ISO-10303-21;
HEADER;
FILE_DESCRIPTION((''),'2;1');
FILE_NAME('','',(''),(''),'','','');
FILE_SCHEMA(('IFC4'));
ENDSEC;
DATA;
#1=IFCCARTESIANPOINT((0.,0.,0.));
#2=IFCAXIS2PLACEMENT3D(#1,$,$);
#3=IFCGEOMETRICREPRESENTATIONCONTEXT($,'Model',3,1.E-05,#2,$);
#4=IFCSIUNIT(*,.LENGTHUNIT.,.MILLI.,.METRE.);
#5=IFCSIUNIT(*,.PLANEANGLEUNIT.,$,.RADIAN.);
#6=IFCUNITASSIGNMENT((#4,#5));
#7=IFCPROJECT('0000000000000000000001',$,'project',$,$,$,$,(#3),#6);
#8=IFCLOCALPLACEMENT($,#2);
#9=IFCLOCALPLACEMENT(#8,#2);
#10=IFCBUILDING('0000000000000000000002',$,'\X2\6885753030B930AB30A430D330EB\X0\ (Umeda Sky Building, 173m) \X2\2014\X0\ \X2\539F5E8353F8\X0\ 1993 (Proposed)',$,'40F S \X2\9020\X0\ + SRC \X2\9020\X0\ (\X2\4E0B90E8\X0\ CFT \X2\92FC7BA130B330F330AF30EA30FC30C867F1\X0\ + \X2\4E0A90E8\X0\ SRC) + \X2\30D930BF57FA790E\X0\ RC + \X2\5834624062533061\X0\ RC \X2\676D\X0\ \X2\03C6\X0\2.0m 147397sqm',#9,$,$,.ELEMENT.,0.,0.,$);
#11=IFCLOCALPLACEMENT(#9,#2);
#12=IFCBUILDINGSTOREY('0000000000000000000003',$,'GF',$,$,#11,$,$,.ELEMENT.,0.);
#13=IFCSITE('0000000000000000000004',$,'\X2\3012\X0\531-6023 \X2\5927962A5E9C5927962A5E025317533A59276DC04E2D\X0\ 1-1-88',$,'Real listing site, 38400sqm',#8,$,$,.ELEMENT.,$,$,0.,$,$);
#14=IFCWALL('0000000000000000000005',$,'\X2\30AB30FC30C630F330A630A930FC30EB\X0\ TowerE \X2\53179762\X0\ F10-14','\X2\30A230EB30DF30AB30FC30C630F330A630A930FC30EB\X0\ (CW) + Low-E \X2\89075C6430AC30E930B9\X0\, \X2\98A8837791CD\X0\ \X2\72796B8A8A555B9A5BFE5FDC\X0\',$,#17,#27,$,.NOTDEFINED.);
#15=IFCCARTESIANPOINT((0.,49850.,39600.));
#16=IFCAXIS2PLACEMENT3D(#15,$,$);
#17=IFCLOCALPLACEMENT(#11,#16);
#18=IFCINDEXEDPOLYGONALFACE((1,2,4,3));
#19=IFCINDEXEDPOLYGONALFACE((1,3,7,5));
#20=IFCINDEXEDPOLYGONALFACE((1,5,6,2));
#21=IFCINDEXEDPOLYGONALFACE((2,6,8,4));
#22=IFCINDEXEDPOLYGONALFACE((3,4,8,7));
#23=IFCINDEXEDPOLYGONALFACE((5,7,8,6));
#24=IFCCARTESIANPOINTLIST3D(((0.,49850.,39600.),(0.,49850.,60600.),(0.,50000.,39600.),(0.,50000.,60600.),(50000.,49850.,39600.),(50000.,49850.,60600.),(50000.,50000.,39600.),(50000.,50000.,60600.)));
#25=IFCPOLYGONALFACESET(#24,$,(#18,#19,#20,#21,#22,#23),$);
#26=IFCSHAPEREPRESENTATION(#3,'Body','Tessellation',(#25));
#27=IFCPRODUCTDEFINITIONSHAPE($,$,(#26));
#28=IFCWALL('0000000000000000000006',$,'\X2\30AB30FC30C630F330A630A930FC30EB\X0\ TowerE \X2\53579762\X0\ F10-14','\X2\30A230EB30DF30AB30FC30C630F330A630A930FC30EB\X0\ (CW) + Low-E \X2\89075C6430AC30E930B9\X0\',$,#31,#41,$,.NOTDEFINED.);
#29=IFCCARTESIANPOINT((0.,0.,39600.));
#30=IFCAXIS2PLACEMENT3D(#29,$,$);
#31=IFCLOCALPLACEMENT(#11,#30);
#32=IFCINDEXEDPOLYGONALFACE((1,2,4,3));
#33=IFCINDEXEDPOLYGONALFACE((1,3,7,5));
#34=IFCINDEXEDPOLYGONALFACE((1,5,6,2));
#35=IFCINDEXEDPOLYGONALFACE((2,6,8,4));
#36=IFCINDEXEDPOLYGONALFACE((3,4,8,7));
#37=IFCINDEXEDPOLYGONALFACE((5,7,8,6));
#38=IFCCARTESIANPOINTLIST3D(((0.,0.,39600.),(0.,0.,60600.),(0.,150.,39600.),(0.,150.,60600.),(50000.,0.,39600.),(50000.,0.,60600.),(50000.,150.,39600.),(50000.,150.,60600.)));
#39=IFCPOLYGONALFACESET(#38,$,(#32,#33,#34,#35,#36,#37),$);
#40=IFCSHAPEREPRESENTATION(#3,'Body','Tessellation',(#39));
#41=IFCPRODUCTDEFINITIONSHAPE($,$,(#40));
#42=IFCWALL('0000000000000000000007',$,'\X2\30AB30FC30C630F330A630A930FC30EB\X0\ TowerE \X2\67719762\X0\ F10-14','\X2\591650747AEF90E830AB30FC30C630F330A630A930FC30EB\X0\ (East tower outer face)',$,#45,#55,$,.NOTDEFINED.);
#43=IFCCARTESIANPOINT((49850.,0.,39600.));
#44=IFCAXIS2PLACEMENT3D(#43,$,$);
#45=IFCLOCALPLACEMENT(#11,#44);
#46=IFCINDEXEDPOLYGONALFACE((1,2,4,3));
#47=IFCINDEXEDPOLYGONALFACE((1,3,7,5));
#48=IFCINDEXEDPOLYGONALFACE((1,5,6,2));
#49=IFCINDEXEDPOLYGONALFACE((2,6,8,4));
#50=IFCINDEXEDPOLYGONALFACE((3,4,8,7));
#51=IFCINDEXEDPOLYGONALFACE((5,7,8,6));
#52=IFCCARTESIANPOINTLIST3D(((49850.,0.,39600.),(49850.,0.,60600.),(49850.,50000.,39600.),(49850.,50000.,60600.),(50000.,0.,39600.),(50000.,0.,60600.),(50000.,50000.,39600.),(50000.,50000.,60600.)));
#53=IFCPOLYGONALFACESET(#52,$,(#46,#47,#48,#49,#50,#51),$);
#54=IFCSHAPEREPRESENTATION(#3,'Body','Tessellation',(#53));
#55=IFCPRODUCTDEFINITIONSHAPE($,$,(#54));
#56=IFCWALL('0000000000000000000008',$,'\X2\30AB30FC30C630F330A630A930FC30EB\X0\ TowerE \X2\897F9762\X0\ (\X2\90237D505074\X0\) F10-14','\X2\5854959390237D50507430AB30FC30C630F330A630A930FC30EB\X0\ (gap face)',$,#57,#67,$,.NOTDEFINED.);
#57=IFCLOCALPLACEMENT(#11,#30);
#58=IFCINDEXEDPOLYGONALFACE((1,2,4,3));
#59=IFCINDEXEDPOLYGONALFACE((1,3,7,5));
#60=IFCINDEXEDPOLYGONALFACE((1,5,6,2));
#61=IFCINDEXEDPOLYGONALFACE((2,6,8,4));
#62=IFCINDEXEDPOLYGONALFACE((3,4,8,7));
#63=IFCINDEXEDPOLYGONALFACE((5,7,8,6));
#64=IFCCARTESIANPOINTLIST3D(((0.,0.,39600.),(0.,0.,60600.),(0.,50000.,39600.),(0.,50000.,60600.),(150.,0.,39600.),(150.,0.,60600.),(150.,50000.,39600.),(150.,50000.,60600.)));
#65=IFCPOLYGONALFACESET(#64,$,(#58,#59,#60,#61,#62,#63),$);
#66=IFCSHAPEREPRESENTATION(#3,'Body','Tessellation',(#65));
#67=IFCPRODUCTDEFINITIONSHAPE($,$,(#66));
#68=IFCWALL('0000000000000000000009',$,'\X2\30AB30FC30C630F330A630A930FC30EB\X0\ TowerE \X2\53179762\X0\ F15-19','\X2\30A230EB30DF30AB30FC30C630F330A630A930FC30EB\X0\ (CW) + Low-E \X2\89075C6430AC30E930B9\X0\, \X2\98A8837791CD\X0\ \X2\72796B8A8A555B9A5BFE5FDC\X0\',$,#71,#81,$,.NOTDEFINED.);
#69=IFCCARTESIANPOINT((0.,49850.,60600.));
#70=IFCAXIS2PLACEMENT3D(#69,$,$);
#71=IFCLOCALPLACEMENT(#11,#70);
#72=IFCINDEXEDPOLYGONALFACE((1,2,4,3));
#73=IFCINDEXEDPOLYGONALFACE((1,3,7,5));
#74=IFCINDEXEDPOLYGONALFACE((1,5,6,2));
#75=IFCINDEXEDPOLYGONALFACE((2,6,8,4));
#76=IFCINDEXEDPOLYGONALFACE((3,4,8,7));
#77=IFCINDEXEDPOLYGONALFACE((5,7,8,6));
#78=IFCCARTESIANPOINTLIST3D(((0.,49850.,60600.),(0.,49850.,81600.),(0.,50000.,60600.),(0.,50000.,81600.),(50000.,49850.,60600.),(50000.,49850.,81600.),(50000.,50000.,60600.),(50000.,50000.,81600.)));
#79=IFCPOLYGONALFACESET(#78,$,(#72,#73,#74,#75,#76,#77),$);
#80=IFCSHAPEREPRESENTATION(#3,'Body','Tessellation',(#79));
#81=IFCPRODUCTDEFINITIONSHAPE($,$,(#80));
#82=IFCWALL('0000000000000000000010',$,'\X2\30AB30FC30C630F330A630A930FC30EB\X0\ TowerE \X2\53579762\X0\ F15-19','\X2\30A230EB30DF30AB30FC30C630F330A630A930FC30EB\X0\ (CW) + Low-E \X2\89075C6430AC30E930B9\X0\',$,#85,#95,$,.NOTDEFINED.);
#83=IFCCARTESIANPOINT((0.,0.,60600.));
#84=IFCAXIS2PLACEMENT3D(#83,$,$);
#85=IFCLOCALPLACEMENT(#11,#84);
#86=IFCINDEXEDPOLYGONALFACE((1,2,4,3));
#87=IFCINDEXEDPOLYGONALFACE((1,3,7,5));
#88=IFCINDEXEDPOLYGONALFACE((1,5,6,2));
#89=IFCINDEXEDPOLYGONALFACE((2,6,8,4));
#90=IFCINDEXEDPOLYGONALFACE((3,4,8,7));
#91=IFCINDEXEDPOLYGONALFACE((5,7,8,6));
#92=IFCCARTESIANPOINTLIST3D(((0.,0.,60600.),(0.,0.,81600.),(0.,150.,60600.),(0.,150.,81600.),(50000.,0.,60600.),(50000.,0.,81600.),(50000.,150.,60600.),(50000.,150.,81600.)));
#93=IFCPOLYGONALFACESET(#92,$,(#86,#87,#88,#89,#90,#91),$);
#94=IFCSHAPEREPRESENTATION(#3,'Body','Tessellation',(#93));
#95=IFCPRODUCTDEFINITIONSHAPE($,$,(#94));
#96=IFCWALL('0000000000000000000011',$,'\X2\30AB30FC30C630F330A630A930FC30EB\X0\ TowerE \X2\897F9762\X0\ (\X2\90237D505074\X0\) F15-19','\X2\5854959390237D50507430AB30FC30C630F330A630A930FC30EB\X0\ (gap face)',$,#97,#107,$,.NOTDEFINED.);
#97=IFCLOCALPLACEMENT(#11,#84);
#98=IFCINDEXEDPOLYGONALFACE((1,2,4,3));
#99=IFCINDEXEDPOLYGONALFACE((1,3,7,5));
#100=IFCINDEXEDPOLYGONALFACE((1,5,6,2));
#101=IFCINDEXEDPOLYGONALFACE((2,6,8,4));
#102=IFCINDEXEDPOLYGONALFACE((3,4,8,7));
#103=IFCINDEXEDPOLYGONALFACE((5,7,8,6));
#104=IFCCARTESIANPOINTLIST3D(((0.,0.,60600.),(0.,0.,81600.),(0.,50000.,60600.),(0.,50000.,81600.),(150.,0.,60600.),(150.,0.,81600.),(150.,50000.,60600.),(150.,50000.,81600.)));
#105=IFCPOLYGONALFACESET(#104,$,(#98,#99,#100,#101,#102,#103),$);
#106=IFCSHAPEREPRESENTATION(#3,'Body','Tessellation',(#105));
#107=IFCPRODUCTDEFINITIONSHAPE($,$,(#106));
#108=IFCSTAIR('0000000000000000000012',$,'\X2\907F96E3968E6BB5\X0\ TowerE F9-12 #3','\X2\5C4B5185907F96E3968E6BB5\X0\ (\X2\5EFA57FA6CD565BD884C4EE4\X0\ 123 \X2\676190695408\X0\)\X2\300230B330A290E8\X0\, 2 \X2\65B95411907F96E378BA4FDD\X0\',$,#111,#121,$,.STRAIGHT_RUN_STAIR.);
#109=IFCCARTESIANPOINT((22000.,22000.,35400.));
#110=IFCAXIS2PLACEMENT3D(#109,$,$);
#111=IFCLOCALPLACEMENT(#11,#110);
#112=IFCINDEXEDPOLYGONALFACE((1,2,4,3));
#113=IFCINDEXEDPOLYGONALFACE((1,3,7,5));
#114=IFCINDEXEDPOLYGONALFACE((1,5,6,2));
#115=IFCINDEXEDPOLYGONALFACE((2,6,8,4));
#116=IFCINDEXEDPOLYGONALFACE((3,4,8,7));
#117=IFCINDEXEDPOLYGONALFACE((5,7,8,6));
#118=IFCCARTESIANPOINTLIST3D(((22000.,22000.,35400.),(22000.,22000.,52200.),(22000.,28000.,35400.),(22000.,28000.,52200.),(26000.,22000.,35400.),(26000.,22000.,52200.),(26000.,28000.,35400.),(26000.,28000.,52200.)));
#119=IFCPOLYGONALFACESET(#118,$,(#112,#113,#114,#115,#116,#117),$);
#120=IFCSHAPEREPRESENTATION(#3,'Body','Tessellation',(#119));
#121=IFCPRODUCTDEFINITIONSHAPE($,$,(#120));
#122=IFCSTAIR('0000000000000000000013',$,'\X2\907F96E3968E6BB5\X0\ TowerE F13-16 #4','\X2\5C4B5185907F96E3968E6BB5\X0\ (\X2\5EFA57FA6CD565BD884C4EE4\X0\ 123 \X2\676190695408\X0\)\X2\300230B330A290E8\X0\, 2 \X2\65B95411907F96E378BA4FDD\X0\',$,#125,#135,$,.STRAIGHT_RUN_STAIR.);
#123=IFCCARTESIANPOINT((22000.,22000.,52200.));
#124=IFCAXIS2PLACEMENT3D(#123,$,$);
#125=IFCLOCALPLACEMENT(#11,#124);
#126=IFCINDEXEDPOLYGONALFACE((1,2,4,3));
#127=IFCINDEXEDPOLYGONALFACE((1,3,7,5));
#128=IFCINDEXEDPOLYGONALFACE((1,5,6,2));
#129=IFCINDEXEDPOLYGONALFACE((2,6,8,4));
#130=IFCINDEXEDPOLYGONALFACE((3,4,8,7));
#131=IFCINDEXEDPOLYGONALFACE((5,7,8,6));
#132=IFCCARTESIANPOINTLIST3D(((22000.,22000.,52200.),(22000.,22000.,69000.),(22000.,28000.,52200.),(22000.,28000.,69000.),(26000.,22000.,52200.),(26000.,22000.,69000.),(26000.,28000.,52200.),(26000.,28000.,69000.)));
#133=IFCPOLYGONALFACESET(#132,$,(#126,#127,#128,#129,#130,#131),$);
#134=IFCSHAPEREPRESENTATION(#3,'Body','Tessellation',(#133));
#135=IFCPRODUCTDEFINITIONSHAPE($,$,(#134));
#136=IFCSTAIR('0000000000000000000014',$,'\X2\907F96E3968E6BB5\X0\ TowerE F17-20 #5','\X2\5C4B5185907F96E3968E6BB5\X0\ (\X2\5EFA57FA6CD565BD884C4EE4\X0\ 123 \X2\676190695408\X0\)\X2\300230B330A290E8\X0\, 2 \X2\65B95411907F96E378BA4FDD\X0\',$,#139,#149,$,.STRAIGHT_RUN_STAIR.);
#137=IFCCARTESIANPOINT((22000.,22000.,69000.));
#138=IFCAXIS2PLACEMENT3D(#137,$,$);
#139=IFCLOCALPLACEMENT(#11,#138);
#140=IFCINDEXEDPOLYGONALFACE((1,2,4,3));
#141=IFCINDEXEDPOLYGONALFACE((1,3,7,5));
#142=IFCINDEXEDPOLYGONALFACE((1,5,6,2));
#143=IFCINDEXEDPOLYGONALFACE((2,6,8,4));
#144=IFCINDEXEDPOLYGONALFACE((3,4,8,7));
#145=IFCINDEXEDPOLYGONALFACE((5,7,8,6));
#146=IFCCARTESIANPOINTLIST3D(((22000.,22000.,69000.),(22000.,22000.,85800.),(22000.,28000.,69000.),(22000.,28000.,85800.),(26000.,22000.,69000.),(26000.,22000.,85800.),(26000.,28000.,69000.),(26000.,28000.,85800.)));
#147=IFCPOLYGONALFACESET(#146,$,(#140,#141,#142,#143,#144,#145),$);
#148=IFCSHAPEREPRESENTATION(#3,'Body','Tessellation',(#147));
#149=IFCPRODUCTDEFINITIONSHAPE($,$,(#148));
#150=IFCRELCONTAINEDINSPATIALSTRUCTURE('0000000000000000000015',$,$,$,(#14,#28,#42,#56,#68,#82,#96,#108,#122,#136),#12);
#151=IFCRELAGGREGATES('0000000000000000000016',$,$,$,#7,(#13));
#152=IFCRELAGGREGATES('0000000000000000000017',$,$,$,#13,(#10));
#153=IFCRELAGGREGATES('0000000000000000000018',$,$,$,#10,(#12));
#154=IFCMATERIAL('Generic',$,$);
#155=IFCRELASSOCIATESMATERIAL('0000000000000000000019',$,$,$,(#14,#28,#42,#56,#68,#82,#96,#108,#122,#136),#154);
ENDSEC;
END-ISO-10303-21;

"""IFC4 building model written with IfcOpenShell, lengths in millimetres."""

from ifc_helpers import new_model, si_unit, frame, frame_2d, origin, place, context, project, spatial, rectangle, extrude, material, element, save


model = new_model("IFC4")

# Units and contexts
model_context = context("Model", 3, precision=1e-05, world=origin())
ifc_project = project(units=[si_unit("LENGTHUNIT", "METRE", prefix="MILLI"), si_unit("PLANEANGLEUNIT", "RADIAN")], contexts=[model_context])

# Site, building, storey
site_placement = place(None, origin())
site = spatial("IfcSite", under=ifc_project, at=site_placement, Name="〒531-6023 大阪府大阪市北区大淀中 1-1-88", ObjectType="Real listing site, 38400sqm", CompositionType="ELEMENT", RefElevation=0.0)
building_placement = place(site_placement, origin())
building = spatial("IfcBuilding", under=site, at=building_placement, Name="梅田スカイビル (Umeda Sky Building, 173m) — 原広司 1993 (Proposed)", ObjectType="40F S 造 + SRC 造 (下部 CFT 鋼管コンクリート柱 + 上部 SRC) + ベタ基礎 RC + 場所打ち RC 杭 φ2.0m 147397sqm", CompositionType="ELEMENT", ElevationOfRefHeight=0.0, ElevationOfTerrain=0.0)
storey_placement = place(building_placement, origin())
storey = spatial("IfcBuildingStorey", under=building, at=storey_placement, Name="GF", CompositionType="ELEMENT", Elevation=0.0)

# Walls
ifc_material_1 = material(Name="Generic")
wall_1_placement = place(storey_placement, frame((0.0, 49850.0, 39600.0)))
element("IfcWall", 1, at=wall_1_placement, inside=storey, material=ifc_material_1, Name="カーテンウォール TowerE 北面 F10-14", Description="アルミカーテンウォール (CW) + Low-E 複層ガラス, 風荷重 特殊評定対応", PredefinedType="NOTDEFINED", context=model_context, shape_type="SweptSolid", body=[
    extrude(rectangle(XDim=50000.0, YDim=150.0, at=frame_2d((25000.0, 75.0))), frame((0.0, 49850.0, 39600.0)), (0.0, 0.0, 1.0), 21000.0),
])
wall_2_placement = place(storey_placement, frame((0.0, 0.0, 39600.0)))
element("IfcWall", 2, at=wall_2_placement, inside=storey, material=ifc_material_1, Name="カーテンウォール TowerE 南面 F10-14", Description="アルミカーテンウォール (CW) + Low-E 複層ガラス", PredefinedType="NOTDEFINED", context=model_context, shape_type="SweptSolid", body=[
    extrude(rectangle(XDim=50000.0, YDim=150.0, at=frame_2d((25000.0, 75.0))), frame((0.0, 0.0, 39600.0)), (0.0, 0.0, 1.0), 21000.0),
])
wall_3_placement = place(storey_placement, frame((49850.0, 0.0, 39600.0)))
element("IfcWall", 3, at=wall_3_placement, inside=storey, material=ifc_material_1, Name="カーテンウォール TowerE 東面 F10-14", Description="外側端部カーテンウォール (East tower outer face)", PredefinedType="NOTDEFINED", context=model_context, shape_type="SweptSolid", body=[
    extrude(rectangle(XDim=150.0, YDim=50000.0, at=frame_2d((75.0, 25000.0))), frame((49850.0, 0.0, 39600.0)), (0.0, 0.0, 1.0), 21000.0),
])
wall_4_placement = place(storey_placement, frame((0.0, 0.0, 39600.0)))
element("IfcWall", 4, at=wall_4_placement, inside=storey, material=ifc_material_1, Name="カーテンウォール TowerE 西面 (連結側) F10-14", Description="塔間連結側カーテンウォール (gap face)", PredefinedType="NOTDEFINED", context=model_context, shape_type="SweptSolid", body=[
    extrude(rectangle(XDim=150.0, YDim=50000.0, at=frame_2d((75.0, 25000.0))), frame((0.0, 0.0, 39600.0)), (0.0, 0.0, 1.0), 21000.0),
])
wall_5_placement = place(storey_placement, frame((0.0, 49850.0, 60600.0)))
element("IfcWall", 5, at=wall_5_placement, inside=storey, material=ifc_material_1, Name="カーテンウォール TowerE 北面 F15-19", Description="アルミカーテンウォール (CW) + Low-E 複層ガラス, 風荷重 特殊評定対応", PredefinedType="NOTDEFINED", context=model_context, shape_type="SweptSolid", body=[
    extrude(rectangle(XDim=50000.0, YDim=150.0, at=frame_2d((25000.0, 75.0))), frame((0.0, 49850.0, 60600.0)), (0.0, 0.0, 1.0), 21000.0),
])
wall_6_placement = place(storey_placement, frame((0.0, 0.0, 60600.0)))
element("IfcWall", 6, at=wall_6_placement, inside=storey, material=ifc_material_1, Name="カーテンウォール TowerE 南面 F15-19", Description="アルミカーテンウォール (CW) + Low-E 複層ガラス", PredefinedType="NOTDEFINED", context=model_context, shape_type="SweptSolid", body=[
    extrude(rectangle(XDim=50000.0, YDim=150.0, at=frame_2d((25000.0, 75.0))), frame((0.0, 0.0, 60600.0)), (0.0, 0.0, 1.0), 21000.0),
])
wall_7_placement = place(storey_placement, frame((0.0, 0.0, 60600.0)))
element("IfcWall", 7, at=wall_7_placement, inside=storey, material=ifc_material_1, Name="カーテンウォール TowerE 西面 (連結側) F15-19", Description="塔間連結側カーテンウォール (gap face)", PredefinedType="NOTDEFINED", context=model_context, shape_type="SweptSolid", body=[
    extrude(rectangle(XDim=150.0, YDim=50000.0, at=frame_2d((75.0, 25000.0))), frame((0.0, 0.0, 60600.0)), (0.0, 0.0, 1.0), 21000.0),
])

# Stairs
stair_1_placement = place(storey_placement, frame((22000.0, 22000.0, 35400.0)))
element("IfcStair", 8, at=stair_1_placement, inside=storey, material=ifc_material_1, Name="避難階段 TowerE F9-12 #3", Description="屋内避難階段 (建基法施行令 123 条適合)。コア部, 2 方向避難確保", PredefinedType="STRAIGHT_RUN_STAIR", context=model_context, shape_type="SweptSolid", body=[
    extrude(rectangle(XDim=4000.0, YDim=6000.0, at=frame_2d((2000.0, 3000.0))), frame((22000.0, 22000.0, 35400.0)), (0.0, 0.0, 1.0), 16800.0),
])
stair_2_placement = place(storey_placement, frame((22000.0, 22000.0, 52200.0)))
element("IfcStair", 9, at=stair_2_placement, inside=storey, material=ifc_material_1, Name="避難階段 TowerE F13-16 #4", Description="屋内避難階段 (建基法施行令 123 条適合)。コア部, 2 方向避難確保", PredefinedType="STRAIGHT_RUN_STAIR", context=model_context, shape_type="SweptSolid", body=[
    extrude(rectangle(XDim=4000.0, YDim=6000.0, at=frame_2d((2000.0, 3000.0))), frame((22000.0, 22000.0, 52200.0)), (0.0, 0.0, 1.0), 16800.0),
])
stair_3_placement = place(storey_placement, frame((22000.0, 22000.0, 69000.0)))
element("IfcStair", 10, at=stair_3_placement, inside=storey, material=ifc_material_1, Name="避難階段 TowerE F17-20 #5", Description="屋内避難階段 (建基法施行令 123 条適合)。コア部, 2 方向避難確保", PredefinedType="STRAIGHT_RUN_STAIR", context=model_context, shape_type="SweptSolid", body=[
    extrude(rectangle(XDim=4000.0, YDim=6000.0, at=frame_2d((2000.0, 3000.0))), frame((22000.0, 22000.0, 69000.0)), (0.0, 0.0, 1.0), 16800.0),
])

save(model, "model.ifc")
